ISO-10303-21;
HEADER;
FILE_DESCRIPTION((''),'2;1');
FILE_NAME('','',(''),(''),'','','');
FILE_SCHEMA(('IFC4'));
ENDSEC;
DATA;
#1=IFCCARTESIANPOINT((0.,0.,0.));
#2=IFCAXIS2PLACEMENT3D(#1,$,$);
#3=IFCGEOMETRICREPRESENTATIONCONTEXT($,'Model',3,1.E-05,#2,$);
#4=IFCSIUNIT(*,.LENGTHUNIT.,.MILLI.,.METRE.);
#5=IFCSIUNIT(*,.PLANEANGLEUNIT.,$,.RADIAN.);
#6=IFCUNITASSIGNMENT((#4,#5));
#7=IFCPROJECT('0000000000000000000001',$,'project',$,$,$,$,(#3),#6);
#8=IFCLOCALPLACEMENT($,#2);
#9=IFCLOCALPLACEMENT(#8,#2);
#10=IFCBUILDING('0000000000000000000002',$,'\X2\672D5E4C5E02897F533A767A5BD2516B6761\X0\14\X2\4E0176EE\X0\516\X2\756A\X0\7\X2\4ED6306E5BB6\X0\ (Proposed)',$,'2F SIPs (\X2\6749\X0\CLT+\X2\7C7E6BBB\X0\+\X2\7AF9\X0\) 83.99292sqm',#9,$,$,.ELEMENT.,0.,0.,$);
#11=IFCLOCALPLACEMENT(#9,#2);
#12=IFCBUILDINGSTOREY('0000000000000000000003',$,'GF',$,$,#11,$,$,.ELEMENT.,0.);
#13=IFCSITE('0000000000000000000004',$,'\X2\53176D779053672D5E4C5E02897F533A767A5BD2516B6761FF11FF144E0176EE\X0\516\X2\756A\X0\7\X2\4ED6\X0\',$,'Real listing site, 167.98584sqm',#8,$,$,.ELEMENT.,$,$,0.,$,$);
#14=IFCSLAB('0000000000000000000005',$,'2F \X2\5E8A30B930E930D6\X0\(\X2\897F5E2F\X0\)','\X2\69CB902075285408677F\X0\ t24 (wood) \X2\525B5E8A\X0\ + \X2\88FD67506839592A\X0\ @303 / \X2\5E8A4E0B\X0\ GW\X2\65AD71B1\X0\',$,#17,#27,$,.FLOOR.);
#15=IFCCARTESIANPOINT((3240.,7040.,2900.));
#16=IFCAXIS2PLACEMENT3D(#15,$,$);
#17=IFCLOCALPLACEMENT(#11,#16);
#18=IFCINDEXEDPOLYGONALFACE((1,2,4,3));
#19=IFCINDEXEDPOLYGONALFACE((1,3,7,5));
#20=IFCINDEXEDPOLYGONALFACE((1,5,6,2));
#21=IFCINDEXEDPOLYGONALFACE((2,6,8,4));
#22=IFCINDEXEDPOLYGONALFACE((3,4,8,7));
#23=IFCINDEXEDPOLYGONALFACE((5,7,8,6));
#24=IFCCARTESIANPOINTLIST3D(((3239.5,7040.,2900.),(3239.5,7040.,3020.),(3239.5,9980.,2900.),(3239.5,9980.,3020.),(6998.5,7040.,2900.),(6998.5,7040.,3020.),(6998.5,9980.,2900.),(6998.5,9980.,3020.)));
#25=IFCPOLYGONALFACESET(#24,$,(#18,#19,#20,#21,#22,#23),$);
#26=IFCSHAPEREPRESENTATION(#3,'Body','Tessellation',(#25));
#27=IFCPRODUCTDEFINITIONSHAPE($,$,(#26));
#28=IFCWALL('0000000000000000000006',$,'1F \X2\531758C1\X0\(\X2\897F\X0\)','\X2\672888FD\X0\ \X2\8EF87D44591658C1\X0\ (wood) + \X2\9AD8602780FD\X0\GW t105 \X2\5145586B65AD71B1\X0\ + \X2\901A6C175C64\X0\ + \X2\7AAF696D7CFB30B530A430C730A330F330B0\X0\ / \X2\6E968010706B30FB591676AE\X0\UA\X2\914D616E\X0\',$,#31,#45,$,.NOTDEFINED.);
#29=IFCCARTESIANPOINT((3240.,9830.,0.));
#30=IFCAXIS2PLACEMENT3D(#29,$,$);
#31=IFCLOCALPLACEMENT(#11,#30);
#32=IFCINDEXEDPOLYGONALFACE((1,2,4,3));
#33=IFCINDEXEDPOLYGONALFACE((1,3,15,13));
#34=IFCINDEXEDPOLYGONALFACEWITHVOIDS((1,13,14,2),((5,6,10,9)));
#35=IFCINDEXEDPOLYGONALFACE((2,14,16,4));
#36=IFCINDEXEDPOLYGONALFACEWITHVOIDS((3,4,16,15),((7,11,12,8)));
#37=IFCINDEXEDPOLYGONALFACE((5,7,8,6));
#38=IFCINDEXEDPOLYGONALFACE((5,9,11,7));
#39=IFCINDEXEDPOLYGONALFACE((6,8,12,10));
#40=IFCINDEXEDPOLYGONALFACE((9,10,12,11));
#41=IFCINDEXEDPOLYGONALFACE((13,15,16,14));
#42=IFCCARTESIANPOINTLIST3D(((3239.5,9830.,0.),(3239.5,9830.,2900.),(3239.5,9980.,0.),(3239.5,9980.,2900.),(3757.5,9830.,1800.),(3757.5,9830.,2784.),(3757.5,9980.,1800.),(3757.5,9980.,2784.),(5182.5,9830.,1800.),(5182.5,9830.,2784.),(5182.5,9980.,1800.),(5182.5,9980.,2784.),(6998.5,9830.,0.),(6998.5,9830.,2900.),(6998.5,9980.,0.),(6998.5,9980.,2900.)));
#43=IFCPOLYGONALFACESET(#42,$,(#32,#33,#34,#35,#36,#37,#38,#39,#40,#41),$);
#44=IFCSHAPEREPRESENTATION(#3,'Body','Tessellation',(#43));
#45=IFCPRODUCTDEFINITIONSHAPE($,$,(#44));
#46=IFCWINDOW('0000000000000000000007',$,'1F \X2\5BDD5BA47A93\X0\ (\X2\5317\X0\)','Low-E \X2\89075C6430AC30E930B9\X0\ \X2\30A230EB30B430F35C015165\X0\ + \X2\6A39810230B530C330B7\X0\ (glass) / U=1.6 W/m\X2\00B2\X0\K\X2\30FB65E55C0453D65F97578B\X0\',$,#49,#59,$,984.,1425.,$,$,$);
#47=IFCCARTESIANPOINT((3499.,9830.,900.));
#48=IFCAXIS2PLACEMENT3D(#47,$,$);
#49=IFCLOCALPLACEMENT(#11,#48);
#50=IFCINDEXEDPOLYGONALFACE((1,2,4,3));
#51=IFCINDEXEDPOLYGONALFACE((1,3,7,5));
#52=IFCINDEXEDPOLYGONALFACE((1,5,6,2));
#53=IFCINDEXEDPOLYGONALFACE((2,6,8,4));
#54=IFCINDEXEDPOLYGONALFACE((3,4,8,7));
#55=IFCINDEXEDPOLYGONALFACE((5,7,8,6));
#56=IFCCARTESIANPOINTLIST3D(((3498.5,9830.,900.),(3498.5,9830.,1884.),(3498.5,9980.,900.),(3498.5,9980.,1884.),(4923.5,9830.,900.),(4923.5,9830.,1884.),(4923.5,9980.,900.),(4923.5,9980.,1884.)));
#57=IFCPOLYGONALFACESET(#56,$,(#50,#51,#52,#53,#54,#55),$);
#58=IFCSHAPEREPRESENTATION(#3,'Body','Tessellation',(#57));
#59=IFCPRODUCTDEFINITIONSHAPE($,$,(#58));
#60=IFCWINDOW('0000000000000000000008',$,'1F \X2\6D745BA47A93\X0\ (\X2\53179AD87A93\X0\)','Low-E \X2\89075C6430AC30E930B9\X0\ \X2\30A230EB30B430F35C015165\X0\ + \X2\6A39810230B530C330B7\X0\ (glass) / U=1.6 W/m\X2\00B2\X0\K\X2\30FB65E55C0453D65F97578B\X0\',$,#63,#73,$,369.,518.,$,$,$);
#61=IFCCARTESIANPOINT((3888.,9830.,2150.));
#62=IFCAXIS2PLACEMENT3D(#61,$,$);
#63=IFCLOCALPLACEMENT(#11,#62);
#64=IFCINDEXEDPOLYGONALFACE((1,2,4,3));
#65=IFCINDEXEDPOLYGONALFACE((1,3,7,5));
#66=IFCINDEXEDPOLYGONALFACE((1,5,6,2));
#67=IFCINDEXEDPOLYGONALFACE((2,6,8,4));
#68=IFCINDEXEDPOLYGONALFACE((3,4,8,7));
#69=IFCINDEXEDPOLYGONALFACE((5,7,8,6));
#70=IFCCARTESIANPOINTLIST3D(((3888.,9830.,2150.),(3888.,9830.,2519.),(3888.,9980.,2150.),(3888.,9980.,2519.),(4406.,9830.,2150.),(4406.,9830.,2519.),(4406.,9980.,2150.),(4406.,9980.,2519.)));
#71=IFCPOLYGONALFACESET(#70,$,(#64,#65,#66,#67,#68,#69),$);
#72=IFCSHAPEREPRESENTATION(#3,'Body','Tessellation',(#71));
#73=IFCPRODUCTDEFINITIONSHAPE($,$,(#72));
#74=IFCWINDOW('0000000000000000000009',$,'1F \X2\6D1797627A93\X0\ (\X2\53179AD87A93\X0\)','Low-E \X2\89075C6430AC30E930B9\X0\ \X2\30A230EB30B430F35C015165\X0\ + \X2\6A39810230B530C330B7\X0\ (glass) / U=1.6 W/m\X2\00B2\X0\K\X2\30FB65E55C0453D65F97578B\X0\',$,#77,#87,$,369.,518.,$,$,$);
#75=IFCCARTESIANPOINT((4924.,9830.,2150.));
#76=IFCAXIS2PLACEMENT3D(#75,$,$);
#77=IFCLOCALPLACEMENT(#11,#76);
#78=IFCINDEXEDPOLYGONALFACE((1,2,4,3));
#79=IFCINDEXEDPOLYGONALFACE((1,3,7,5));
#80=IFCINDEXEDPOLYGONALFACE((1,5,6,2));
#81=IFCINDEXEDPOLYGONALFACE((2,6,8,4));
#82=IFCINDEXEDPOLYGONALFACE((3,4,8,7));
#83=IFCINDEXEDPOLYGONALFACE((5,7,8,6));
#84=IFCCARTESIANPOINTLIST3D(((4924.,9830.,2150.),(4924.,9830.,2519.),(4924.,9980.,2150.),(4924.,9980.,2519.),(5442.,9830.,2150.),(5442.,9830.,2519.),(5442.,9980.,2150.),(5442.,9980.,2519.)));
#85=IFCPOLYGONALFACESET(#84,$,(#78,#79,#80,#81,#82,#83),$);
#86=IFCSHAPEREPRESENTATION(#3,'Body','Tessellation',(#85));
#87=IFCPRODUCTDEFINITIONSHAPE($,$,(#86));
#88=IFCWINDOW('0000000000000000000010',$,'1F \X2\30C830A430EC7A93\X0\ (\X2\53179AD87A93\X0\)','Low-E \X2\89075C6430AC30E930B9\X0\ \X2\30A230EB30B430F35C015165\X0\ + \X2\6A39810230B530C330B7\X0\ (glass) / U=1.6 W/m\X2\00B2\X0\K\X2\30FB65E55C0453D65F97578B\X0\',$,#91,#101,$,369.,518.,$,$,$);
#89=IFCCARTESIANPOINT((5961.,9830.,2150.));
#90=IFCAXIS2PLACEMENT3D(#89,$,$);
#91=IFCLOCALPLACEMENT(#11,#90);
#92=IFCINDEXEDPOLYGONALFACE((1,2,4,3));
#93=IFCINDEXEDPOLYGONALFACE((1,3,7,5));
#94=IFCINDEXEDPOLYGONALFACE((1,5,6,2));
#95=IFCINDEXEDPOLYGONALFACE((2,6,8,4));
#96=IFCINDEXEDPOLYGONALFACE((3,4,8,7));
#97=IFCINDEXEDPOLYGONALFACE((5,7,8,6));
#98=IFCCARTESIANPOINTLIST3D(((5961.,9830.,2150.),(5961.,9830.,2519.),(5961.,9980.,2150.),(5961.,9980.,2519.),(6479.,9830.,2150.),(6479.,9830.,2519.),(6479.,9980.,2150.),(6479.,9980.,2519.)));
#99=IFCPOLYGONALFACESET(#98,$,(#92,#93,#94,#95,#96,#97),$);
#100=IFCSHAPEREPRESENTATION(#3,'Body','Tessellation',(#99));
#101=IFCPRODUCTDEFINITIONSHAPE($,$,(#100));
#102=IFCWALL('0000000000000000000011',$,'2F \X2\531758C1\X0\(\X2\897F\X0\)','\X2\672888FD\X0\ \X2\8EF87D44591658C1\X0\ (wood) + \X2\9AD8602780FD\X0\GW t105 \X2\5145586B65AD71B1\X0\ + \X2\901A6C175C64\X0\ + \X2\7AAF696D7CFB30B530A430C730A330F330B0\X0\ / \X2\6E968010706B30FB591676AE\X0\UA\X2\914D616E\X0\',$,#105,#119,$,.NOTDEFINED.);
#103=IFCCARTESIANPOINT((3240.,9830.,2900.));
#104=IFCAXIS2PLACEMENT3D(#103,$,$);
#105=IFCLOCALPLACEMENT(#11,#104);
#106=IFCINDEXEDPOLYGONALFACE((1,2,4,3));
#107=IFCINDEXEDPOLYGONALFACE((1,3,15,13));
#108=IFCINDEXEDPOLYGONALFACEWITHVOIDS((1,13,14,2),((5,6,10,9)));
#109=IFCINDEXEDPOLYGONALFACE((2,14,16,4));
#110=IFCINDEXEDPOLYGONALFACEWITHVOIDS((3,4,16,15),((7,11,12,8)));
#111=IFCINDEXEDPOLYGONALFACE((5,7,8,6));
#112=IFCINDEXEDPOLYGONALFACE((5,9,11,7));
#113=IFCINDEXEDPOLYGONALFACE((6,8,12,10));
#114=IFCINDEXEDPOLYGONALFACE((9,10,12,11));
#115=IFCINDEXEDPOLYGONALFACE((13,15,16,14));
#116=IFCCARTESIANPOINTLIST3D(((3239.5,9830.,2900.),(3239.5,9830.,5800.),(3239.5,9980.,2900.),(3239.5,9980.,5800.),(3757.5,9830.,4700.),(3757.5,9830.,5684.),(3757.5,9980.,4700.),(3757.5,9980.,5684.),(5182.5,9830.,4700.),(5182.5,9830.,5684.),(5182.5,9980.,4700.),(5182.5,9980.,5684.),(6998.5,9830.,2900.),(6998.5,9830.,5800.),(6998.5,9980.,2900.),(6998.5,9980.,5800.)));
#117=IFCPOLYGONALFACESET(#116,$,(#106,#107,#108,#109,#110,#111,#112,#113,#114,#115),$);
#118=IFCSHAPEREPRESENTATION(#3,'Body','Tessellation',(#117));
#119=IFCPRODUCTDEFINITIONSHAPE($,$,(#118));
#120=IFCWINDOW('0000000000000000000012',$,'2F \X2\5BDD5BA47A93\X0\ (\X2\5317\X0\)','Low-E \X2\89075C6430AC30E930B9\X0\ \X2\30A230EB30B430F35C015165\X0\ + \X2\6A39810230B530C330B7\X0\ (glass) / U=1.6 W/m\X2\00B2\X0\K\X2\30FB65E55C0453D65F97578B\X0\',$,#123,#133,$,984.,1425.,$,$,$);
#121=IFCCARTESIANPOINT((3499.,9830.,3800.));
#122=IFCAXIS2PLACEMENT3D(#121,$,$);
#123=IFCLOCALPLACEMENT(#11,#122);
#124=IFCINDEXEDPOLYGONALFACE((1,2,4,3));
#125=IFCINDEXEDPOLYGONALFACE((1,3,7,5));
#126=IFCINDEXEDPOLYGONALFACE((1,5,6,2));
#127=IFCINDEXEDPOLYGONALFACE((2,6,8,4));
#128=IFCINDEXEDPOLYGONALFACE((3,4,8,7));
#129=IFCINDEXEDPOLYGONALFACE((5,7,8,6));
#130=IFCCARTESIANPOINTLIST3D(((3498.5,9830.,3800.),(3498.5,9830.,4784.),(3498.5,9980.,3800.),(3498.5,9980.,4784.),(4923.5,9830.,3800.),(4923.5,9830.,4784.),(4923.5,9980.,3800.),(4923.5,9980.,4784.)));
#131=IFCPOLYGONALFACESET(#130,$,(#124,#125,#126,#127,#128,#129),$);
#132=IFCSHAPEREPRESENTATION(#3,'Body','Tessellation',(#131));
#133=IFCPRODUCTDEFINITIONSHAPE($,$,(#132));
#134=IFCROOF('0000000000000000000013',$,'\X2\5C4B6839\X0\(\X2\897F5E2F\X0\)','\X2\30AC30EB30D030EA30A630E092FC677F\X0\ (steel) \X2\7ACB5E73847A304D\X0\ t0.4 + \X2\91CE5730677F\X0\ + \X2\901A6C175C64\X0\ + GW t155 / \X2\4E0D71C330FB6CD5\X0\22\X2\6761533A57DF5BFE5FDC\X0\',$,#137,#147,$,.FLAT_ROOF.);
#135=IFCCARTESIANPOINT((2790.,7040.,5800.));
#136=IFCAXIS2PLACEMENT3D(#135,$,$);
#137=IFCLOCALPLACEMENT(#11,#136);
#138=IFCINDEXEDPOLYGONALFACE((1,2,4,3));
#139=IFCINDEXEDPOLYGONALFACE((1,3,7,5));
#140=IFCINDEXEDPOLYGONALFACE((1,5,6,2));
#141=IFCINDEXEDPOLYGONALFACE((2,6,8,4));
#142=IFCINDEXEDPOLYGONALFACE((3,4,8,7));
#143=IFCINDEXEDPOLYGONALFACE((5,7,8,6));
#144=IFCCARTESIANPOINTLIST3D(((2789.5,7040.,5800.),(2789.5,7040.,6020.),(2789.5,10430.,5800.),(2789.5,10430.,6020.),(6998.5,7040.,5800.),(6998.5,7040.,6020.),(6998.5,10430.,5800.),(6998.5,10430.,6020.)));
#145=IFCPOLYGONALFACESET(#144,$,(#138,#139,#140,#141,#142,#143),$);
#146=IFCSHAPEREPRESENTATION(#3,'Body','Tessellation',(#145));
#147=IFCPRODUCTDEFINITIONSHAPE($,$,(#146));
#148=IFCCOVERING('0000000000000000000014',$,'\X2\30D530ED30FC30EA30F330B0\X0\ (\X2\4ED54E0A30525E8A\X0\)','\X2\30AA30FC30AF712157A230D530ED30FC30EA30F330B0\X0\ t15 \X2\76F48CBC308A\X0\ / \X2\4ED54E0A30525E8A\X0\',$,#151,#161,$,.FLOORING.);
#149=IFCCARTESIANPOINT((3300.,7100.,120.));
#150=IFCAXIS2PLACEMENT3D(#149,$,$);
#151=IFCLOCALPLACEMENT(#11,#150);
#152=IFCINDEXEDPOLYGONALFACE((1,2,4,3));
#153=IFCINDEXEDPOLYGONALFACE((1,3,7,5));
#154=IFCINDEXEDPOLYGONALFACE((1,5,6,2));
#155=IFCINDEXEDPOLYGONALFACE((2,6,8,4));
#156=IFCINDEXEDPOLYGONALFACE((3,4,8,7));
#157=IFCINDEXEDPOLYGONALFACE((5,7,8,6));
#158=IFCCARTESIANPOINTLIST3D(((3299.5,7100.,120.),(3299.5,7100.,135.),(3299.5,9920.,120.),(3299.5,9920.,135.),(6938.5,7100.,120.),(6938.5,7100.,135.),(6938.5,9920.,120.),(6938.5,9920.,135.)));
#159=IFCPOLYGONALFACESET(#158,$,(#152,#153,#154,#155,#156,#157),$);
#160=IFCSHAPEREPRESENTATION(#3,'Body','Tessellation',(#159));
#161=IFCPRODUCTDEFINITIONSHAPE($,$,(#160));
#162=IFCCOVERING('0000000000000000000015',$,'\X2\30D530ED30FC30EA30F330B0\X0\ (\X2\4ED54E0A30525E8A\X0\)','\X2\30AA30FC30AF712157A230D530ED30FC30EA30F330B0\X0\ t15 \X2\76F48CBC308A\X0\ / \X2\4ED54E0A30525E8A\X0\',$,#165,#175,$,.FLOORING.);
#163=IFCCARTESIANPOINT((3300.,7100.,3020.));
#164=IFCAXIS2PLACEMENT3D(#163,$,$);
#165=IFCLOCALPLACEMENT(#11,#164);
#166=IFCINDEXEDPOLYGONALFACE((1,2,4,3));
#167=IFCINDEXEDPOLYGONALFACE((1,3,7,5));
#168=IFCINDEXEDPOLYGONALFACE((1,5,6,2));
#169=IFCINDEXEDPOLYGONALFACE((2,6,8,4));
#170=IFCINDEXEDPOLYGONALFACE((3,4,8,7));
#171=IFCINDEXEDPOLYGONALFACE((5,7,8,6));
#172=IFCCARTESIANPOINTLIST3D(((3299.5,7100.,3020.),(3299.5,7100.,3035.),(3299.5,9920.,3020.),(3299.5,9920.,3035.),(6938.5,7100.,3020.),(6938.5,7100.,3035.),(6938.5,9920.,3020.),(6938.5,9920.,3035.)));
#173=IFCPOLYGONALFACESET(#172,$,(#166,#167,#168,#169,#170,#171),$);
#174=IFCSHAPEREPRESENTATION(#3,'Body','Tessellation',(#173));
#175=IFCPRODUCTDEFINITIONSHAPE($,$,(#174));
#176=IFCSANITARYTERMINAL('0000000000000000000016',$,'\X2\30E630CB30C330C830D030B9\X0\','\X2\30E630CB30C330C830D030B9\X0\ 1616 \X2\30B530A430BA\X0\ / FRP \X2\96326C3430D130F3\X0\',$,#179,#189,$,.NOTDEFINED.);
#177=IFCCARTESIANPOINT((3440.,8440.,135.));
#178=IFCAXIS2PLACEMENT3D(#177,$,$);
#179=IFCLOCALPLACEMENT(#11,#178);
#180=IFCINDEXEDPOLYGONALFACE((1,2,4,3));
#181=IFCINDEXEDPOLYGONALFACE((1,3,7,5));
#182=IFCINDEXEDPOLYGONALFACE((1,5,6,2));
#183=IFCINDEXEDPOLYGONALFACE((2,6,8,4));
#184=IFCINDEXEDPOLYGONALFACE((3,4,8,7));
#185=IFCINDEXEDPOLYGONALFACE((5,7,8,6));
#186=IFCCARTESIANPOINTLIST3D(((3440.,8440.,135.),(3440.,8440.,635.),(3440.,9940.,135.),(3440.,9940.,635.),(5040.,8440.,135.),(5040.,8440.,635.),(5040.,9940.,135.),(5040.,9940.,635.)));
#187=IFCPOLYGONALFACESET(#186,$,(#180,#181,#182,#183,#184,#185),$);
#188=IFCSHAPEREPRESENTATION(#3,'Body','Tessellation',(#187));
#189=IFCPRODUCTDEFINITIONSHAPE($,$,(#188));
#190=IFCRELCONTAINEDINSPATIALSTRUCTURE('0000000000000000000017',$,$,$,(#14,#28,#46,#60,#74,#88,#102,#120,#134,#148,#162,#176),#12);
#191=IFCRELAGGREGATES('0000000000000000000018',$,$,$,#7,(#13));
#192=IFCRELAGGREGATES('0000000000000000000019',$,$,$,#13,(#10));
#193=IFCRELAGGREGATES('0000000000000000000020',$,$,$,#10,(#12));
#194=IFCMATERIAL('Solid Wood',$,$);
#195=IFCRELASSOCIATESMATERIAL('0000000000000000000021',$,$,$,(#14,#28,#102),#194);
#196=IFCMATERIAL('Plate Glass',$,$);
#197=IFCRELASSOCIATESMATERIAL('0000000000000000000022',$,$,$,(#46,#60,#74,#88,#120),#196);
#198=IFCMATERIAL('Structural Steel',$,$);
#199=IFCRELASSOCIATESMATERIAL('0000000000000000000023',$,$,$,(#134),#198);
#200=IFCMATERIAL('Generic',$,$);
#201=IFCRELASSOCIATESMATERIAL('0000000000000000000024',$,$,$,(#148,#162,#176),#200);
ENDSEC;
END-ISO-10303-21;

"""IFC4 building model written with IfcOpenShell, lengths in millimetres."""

from ifc_helpers import new_model, si_unit, frame, frame_2d, origin, place, context, project, spatial, rectangle, extrude, material, element, fill, save


model = new_model("IFC4")

# Units and contexts
model_context = context("Model", 3, precision=1e-05, world=origin())
ifc_project = project(units=[si_unit("LENGTHUNIT", "METRE", prefix="MILLI"), si_unit("PLANEANGLEUNIT", "RADIAN")], contexts=[model_context])

# Site, building, storey
site_placement = place(None, origin())
site = spatial("IfcSite", under=ifc_project, at=site_placement, Name="北海道札幌市西区発寒八条１４丁目516番7他", ObjectType="Real listing site, 167.98584sqm", CompositionType="ELEMENT", RefElevation=0.0)
building_placement = place(site_placement, origin())
building = spatial("IfcBuilding", under=site, at=building_placement, Name="札幌市西区発寒八条14丁目516番7他の家 (Proposed)", ObjectType="2F SIPs (杉CLT+籾殻+竹) 83.99292sqm", CompositionType="ELEMENT", ElevationOfRefHeight=0.0, ElevationOfTerrain=0.0)
storey_placement = place(building_placement, origin())
storey = spatial("IfcBuildingStorey", under=building, at=storey_placement, Name="GF", CompositionType="ELEMENT", Elevation=0.0)

# Slab
ifc_material_1 = material(Name="Solid Wood")
slab_1_placement = place(storey_placement, frame((3240.0, 7040.0, 2900.0)))
element("IfcSlab", 1, at=slab_1_placement, inside=storey, material=ifc_material_1, Name="2F 床スラブ(西帯)", Description="構造用合板 t24 (wood) 剛床 + 製材根太 @303 / 床下 GW断熱", PredefinedType="FLOOR", context=model_context, shape_type="SweptSolid", body=[
    extrude(rectangle(XDim=3759.0, YDim=2940.0, at=frame_2d((1879.0, 1470.0))), frame((3240.0, 7040.0, 2900.0)), (0.0, 0.0, 1.0), 120.0),
])

# Wall, openings, windows
wall_1_placement = place(storey_placement, frame((3240.0, 9830.0, 0.0)))
wall_1 = element("IfcWall", 2, at=wall_1_placement, inside=storey, material=ifc_material_1, Name="1F 北壁(西)", Description="木製 軸組外壁 (wood) + 高性能GW t105 充填断熱 + 通気層 + 窯業系サイディング / 準耐火・外皮UA配慮", PredefinedType="NOTDEFINED", context=model_context, shape_type="SweptSolid", body=[
    extrude(rectangle(XDim=3759.0, YDim=150.0, at=frame_2d((1879.0, 75.0))), frame((3240.0, 9830.0, 0.0)), (0.0, 0.0, 1.0), 2900.0),
])
opening_1_placement = place(storey_placement, frame((3499.0, 9830.0, 900.0)))
opening_1 = element("IfcOpeningElement", 3, at=opening_1_placement, cuts=wall_1, PredefinedType="NOTDEFINED", context=model_context, shape_type="SweptSolid", body=[
    extrude(rectangle(XDim=1425.0, YDim=150.0, at=frame_2d((712.0, 75.0))), frame((3499.0, 9830.0, 900.0)), (0.0, 0.0, 1.0), 984.0),
])
opening_2_placement = place(storey_placement, frame((3888.0, 9830.0, 2150.0)))
opening_2 = element("IfcOpeningElement", 4, at=opening_2_placement, cuts=wall_1, PredefinedType="NOTDEFINED", context=model_context, shape_type="SweptSolid", body=[
    extrude(rectangle(XDim=518.0, YDim=150.0, at=frame_2d((259.0, 75.0))), frame((3888.0, 9830.0, 2150.0)), (0.0, 0.0, 1.0), 369.0),
])
opening_3_placement = place(storey_placement, frame((4924.0, 9830.0, 2150.0)))
opening_3 = element("IfcOpeningElement", 5, at=opening_3_placement, cuts=wall_1, PredefinedType="NOTDEFINED", context=model_context, shape_type="SweptSolid", body=[
    extrude(rectangle(XDim=518.0, YDim=150.0, at=frame_2d((259.0, 75.0))), frame((4924.0, 9830.0, 2150.0)), (0.0, 0.0, 1.0), 369.0),
])
opening_4_placement = place(storey_placement, frame((5961.0, 9830.0, 2150.0)))
opening_4 = element("IfcOpeningElement", 6, at=opening_4_placement, cuts=wall_1, PredefinedType="NOTDEFINED", context=model_context, shape_type="SweptSolid", body=[
    extrude(rectangle(XDim=518.0, YDim=150.0, at=frame_2d((259.0, 75.0))), frame((5961.0, 9830.0, 2150.0)), (0.0, 0.0, 1.0), 369.0),
])
ifc_material_2 = material(Name="Plate Glass")
window_1_placement = place(storey_placement, frame((3499.0, 9830.0, 900.0)))
window_1 = element("IfcWindow", 7, at=window_1_placement, inside=storey, material=ifc_material_2, Name="1F 寝室窓 (北)", Description="Low-E 複層ガラス アルゴン封入 + 樹脂サッシ (glass) / U=1.6 W/m²K・日射取得型", OverallHeight=984.0, OverallWidth=1425.0, context=model_context, shape_type="SweptSolid", body=[
    extrude(rectangle(XDim=1425.0, YDim=150.0, at=frame_2d((712.0, 75.0))), frame((3499.0, 9830.0, 900.0)), (0.0, 0.0, 1.0), 984.0),
])
fill(opening_1, window_1)
window_2_placement = place(storey_placement, frame((3888.0, 9830.0, 2150.0)))
window_2 = element("IfcWindow", 8, at=window_2_placement, inside=storey, material=ifc_material_2, Name="1F 浴室窓 (北高窓)", Description="Low-E 複層ガラス アルゴン封入 + 樹脂サッシ (glass) / U=1.6 W/m²K・日射取得型", OverallHeight=369.0, OverallWidth=518.0, context=model_context, shape_type="SweptSolid", body=[
    extrude(rectangle(XDim=518.0, YDim=150.0, at=frame_2d((259.0, 75.0))), frame((3888.0, 9830.0, 2150.0)), (0.0, 0.0, 1.0), 369.0),
])
fill(opening_2, window_2)
window_3_placement = place(storey_placement, frame((4924.0, 9830.0, 2150.0)))
window_3 = element("IfcWindow", 9, at=window_3_placement, inside=storey, material=ifc_material_2, Name="1F 洗面窓 (北高窓)", Description="Low-E 複層ガラス アルゴン封入 + 樹脂サッシ (glass) / U=1.6 W/m²K・日射取得型", OverallHeight=369.0, OverallWidth=518.0, context=model_context, shape_type="SweptSolid", body=[
    extrude(rectangle(XDim=518.0, YDim=150.0, at=frame_2d((259.0, 75.0))), frame((4924.0, 9830.0, 2150.0)), (0.0, 0.0, 1.0), 369.0),
])
fill(opening_3, window_3)
window_4_placement = place(storey_placement, frame((5961.0, 9830.0, 2150.0)))
window_4 = element("IfcWindow", 10, at=window_4_placement, inside=storey, material=ifc_material_2, Name="1F トイレ窓 (北高窓)", Description="Low-E 複層ガラス アルゴン封入 + 樹脂サッシ (glass) / U=1.6 W/m²K・日射取得型", OverallHeight=369.0, OverallWidth=518.0, context=model_context, shape_type="SweptSolid", body=[
    extrude(rectangle(XDim=518.0, YDim=150.0, at=frame_2d((259.0, 75.0))), frame((5961.0, 9830.0, 2150.0)), (0.0, 0.0, 1.0), 369.0),
])
fill(opening_4, window_4)

# Wall, opening, window
wall_2_placement = place(storey_placement, frame((3240.0, 9830.0, 2900.0)))
wall_2 = element("IfcWall", 11, at=wall_2_placement, inside=storey, material=ifc_material_1, Name="2F 北壁(西)", Description="木製 軸組外壁 (wood) + 高性能GW t105 充填断熱 + 通気層 + 窯業系サイディング / 準耐火・外皮UA配慮", PredefinedType="NOTDEFINED", context=model_context, shape_type="SweptSolid", body=[
    extrude(rectangle(XDim=3759.0, YDim=150.0, at=frame_2d((1879.0, 75.0))), frame((3240.0, 9830.0, 2900.0)), (0.0, 0.0, 1.0), 2900.0),
])
opening_5_placement = place(storey_placement, frame((3499.0, 9830.0, 3800.0)))
opening_5 = element("IfcOpeningElement", 12, at=opening_5_placement, cuts=wall_2, PredefinedType="NOTDEFINED", context=model_context, shape_type="SweptSolid", body=[
    extrude(rectangle(XDim=1425.0, YDim=150.0, at=frame_2d((712.0, 75.0))), frame((3499.0, 9830.0, 3800.0)), (0.0, 0.0, 1.0), 984.0),
])
window_5_placement = place(storey_placement, frame((3499.0, 9830.0, 3800.0)))
window_5 = element("IfcWindow", 13, at=window_5_placement, inside=storey, material=ifc_material_2, Name="2F 寝室窓 (北)", Description="Low-E 複層ガラス アルゴン封入 + 樹脂サッシ (glass) / U=1.6 W/m²K・日射取得型", OverallHeight=984.0, OverallWidth=1425.0, context=model_context, shape_type="SweptSolid", body=[
    extrude(rectangle(XDim=1425.0, YDim=150.0, at=frame_2d((712.0, 75.0))), frame((3499.0, 9830.0, 3800.0)), (0.0, 0.0, 1.0), 984.0),
])
fill(opening_5, window_5)

# Roof
ifc_material_3 = material(Name="Structural Steel")
for number, where, name in (
    (14, (2790.0, 7040.0, 5800.0), "屋根(西帯)"),
):
    element("IfcRoof", number, at=place(storey_placement, frame(where)), inside=storey, material=ifc_material_3, Name=name, Description="ガルバリウム鋼板 (steel) 立平葺き t0.4 + 野地板 + 通気層 + GW t155 / 不燃・法22条区域対応", PredefinedType="FLAT_ROOF", context=model_context, shape_type="SweptSolid", body=[
        extrude(rectangle(XDim=4209.0, YDim=3390.0, at=frame_2d((2104.0, 1695.0))), frame((2790.0, 7040.0, 5800.0)), (0.0, 0.0, 1.0), 220.0),
    ])

# Coverings
ifc_material_4 = material(Name="Generic")
covering_1_placement = place(storey_placement, frame((3300.0, 7100.0, 120.0)))
element("IfcCovering", 15, at=covering_1_placement, inside=storey, material=ifc_material_4, Name="フローリング (仕上げ床)", Description="オーク無垢フローリング t15 直貼り / 仕上げ床", PredefinedType="FLOORING", context=model_context, shape_type="SweptSolid", body=[
    extrude(rectangle(XDim=3639.0, YDim=2820.0, at=frame_2d((1819.0, 1410.0))), frame((3300.0, 7100.0, 120.0)), (0.0, 0.0, 1.0), 15.0),
])
covering_2_placement = place(storey_placement, frame((3300.0, 7100.0, 3020.0)))
element("IfcCovering", 16, at=covering_2_placement, inside=storey, material=ifc_material_4, Name="フローリング (仕上げ床)", Description="オーク無垢フローリング t15 直貼り / 仕上げ床", PredefinedType="FLOORING", context=model_context, shape_type="SweptSolid", body=[
    extrude(rectangle(XDim=3639.0, YDim=2820.0, at=frame_2d((1819.0, 1410.0))), frame((3300.0, 7100.0, 3020.0)), (0.0, 0.0, 1.0), 15.0),
])

# Sanitary terminal
sanitary_terminal_placement = place(storey_placement, frame((3440.0, 8440.0, 135.0)))
element("IfcSanitaryTerminal", 17, at=sanitary_terminal_placement, inside=storey, material=ifc_material_4, Name="ユニットバス", Description="ユニットバス 1616 サイズ / FRP 防水パン", PredefinedType="NOTDEFINED", context=model_context, shape_type="SweptSolid", body=[
    extrude(rectangle(XDim=1600.0, YDim=1500.0, at=frame_2d((800.0, 750.0))), frame((3440.0, 8440.0, 135.0)), (0.0, 0.0, 1.0), 500.0),
])

save(model, "model.ifc")
